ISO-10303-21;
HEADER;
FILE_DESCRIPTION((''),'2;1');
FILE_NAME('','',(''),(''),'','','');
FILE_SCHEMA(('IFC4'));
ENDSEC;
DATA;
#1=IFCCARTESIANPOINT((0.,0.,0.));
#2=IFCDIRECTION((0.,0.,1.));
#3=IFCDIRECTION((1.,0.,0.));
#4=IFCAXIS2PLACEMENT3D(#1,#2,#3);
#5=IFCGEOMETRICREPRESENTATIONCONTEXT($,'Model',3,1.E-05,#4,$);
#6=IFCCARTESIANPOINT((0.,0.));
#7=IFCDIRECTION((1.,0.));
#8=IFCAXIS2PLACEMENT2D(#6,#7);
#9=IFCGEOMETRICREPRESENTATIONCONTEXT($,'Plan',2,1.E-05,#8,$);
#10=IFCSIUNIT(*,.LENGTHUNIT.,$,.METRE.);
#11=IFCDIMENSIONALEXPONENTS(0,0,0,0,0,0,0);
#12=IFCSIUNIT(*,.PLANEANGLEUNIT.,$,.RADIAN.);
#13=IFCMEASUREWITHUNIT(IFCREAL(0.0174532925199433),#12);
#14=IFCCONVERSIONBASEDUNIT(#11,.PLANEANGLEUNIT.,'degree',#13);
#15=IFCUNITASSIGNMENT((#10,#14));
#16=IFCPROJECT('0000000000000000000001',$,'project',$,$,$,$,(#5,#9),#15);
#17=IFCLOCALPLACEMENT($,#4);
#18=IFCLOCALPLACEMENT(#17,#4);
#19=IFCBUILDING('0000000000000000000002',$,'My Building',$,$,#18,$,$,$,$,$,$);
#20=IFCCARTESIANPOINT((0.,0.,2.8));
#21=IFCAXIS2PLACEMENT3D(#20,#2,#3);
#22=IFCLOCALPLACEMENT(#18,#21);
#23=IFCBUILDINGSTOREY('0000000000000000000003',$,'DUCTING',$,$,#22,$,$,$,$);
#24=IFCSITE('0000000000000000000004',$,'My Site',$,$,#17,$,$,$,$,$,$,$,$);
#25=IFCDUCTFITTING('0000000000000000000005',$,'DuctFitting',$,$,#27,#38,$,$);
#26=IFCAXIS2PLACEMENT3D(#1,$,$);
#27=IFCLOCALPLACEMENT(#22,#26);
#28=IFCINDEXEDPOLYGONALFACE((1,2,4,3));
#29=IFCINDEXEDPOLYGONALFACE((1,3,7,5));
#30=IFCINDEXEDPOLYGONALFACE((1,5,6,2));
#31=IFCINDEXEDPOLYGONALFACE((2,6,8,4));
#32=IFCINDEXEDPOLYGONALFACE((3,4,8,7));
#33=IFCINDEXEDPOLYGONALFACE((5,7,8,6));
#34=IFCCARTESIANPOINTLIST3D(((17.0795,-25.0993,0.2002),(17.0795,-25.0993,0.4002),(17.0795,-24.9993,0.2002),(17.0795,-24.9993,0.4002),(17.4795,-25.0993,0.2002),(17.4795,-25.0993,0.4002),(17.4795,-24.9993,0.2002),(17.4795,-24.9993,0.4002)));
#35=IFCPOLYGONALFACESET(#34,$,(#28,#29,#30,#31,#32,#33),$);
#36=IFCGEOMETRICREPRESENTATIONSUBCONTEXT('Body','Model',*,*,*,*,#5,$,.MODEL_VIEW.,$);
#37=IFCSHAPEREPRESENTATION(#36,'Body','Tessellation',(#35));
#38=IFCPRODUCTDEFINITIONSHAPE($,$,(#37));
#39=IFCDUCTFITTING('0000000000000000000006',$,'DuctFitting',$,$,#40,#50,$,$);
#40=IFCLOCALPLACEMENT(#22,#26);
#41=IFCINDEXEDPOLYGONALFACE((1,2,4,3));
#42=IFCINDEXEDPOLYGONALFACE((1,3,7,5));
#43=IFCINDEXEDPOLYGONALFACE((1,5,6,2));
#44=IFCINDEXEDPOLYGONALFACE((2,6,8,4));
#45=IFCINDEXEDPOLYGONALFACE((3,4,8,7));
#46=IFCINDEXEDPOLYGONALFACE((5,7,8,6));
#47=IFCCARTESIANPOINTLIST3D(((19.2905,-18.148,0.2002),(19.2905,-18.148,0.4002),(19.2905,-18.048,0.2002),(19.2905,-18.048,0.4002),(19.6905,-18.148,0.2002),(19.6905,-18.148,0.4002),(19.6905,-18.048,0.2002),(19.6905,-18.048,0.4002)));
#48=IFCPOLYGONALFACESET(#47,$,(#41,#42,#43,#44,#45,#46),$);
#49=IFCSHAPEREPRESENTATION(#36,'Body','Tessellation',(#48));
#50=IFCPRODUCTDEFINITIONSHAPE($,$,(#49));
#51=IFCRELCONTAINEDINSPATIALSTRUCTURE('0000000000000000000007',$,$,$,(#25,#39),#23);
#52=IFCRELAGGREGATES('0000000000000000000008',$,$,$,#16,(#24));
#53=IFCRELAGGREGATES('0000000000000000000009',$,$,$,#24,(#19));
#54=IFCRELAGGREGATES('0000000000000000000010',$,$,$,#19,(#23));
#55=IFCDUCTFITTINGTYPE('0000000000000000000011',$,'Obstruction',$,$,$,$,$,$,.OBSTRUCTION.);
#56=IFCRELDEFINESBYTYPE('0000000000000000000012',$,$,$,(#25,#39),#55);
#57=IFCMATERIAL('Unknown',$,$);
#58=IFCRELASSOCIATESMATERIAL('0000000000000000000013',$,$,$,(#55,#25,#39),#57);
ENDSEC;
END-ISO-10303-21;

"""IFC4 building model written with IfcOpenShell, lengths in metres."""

from ifc_helpers import new_model, entity, si_unit, converted_unit, frame, origin_with_axes, origin_2d_with_axis, place, context, subcontext, project, spatial, rectangle, extrude, material, material_profile, profile_set, profile_usage, type_object, element, save


model = new_model("IFC4")

# Units and contexts
model_context = context("Model", 3, precision=1e-05, world=origin_with_axes())
plan_context = context("Plan", 2, precision=1e-05, world=origin_2d_with_axis())
body_context = subcontext(model_context, "Body", "Model", "MODEL_VIEW")
ifc_project = project(units=[si_unit("LENGTHUNIT", "METRE"), converted_unit("PLANEANGLEUNIT", "degree", entity("IfcReal", 0.0174532925199433), si_unit("PLANEANGLEUNIT", "RADIAN"), dimensions=[0, 0, 0, 0, 0, 0, 0])], contexts=[model_context, plan_context])

# Site, building, storey
site_placement = place(None, origin_with_axes())
site = spatial("IfcSite", under=ifc_project, at=site_placement, Name="My Site")
building_placement = place(site_placement, origin_with_axes())
building = spatial("IfcBuilding", under=site, at=building_placement, Name="My Building")
storey_placement = place(building_placement, frame((0.0, 0.0, 2.8), z_axis=(0.0, 0.0, 1.0), x_axis=(1.0, 0.0, 0.0)))
storey = spatial("IfcBuildingStorey", under=building, at=storey_placement, Name="DUCTING")

# Shared definitions
ifc_material = material(Name="Unknown")

# Duct fittings
ifc_material_profile_1 = material_profile(ifc_material, rectangle(XDim=0.4, YDim=0.2))
ifc_profile_set_1 = profile_set([ifc_material_profile_1])
duct_fitting_type_1 = type_object("IfcDuctFittingType", Name="Obstruction", PredefinedType="OBSTRUCTION", material=ifc_profile_set_1)
ifc_profile_usage_1 = profile_usage(ifc_profile_set_1, cardinal=5)
duct_fitting_1_placement = place(storey_placement, frame((17.2795, -24.9993, 0.3002), z_axis=(0.0, -1.0, 0.0), x_axis=(1.0, 0.0, 0.0)))
element("IfcDuctFitting", 1, at=duct_fitting_1_placement, inside=storey, type_object=duct_fitting_type_1, material=ifc_profile_usage_1, Name="DuctFitting", context=body_context, shape_type="SweptSolid", body=[
    extrude(rectangle(XDim=0.4, YDim=0.2), origin_with_axes(), (0.0, 0.0, 1.0), 0.1),
])
ifc_profile_usage_2 = profile_usage(ifc_profile_set_1, cardinal=5)
duct_fitting_2_placement = place(storey_placement, frame((19.4905, -18.048, 0.3002), z_axis=(0.0, -1.0, 0.0), x_axis=(1.0, 0.0, 0.0)))
element("IfcDuctFitting", 2, at=duct_fitting_2_placement, inside=storey, type_object=duct_fitting_type_1, material=ifc_profile_usage_2, Name="DuctFitting", context=body_context, shape_type="SweptSolid", body=[
    extrude(rectangle(XDim=0.4, YDim=0.2), origin_with_axes(), (0.0, 0.0, 1.0), 0.1),
])

save(model, "model.ifc")
